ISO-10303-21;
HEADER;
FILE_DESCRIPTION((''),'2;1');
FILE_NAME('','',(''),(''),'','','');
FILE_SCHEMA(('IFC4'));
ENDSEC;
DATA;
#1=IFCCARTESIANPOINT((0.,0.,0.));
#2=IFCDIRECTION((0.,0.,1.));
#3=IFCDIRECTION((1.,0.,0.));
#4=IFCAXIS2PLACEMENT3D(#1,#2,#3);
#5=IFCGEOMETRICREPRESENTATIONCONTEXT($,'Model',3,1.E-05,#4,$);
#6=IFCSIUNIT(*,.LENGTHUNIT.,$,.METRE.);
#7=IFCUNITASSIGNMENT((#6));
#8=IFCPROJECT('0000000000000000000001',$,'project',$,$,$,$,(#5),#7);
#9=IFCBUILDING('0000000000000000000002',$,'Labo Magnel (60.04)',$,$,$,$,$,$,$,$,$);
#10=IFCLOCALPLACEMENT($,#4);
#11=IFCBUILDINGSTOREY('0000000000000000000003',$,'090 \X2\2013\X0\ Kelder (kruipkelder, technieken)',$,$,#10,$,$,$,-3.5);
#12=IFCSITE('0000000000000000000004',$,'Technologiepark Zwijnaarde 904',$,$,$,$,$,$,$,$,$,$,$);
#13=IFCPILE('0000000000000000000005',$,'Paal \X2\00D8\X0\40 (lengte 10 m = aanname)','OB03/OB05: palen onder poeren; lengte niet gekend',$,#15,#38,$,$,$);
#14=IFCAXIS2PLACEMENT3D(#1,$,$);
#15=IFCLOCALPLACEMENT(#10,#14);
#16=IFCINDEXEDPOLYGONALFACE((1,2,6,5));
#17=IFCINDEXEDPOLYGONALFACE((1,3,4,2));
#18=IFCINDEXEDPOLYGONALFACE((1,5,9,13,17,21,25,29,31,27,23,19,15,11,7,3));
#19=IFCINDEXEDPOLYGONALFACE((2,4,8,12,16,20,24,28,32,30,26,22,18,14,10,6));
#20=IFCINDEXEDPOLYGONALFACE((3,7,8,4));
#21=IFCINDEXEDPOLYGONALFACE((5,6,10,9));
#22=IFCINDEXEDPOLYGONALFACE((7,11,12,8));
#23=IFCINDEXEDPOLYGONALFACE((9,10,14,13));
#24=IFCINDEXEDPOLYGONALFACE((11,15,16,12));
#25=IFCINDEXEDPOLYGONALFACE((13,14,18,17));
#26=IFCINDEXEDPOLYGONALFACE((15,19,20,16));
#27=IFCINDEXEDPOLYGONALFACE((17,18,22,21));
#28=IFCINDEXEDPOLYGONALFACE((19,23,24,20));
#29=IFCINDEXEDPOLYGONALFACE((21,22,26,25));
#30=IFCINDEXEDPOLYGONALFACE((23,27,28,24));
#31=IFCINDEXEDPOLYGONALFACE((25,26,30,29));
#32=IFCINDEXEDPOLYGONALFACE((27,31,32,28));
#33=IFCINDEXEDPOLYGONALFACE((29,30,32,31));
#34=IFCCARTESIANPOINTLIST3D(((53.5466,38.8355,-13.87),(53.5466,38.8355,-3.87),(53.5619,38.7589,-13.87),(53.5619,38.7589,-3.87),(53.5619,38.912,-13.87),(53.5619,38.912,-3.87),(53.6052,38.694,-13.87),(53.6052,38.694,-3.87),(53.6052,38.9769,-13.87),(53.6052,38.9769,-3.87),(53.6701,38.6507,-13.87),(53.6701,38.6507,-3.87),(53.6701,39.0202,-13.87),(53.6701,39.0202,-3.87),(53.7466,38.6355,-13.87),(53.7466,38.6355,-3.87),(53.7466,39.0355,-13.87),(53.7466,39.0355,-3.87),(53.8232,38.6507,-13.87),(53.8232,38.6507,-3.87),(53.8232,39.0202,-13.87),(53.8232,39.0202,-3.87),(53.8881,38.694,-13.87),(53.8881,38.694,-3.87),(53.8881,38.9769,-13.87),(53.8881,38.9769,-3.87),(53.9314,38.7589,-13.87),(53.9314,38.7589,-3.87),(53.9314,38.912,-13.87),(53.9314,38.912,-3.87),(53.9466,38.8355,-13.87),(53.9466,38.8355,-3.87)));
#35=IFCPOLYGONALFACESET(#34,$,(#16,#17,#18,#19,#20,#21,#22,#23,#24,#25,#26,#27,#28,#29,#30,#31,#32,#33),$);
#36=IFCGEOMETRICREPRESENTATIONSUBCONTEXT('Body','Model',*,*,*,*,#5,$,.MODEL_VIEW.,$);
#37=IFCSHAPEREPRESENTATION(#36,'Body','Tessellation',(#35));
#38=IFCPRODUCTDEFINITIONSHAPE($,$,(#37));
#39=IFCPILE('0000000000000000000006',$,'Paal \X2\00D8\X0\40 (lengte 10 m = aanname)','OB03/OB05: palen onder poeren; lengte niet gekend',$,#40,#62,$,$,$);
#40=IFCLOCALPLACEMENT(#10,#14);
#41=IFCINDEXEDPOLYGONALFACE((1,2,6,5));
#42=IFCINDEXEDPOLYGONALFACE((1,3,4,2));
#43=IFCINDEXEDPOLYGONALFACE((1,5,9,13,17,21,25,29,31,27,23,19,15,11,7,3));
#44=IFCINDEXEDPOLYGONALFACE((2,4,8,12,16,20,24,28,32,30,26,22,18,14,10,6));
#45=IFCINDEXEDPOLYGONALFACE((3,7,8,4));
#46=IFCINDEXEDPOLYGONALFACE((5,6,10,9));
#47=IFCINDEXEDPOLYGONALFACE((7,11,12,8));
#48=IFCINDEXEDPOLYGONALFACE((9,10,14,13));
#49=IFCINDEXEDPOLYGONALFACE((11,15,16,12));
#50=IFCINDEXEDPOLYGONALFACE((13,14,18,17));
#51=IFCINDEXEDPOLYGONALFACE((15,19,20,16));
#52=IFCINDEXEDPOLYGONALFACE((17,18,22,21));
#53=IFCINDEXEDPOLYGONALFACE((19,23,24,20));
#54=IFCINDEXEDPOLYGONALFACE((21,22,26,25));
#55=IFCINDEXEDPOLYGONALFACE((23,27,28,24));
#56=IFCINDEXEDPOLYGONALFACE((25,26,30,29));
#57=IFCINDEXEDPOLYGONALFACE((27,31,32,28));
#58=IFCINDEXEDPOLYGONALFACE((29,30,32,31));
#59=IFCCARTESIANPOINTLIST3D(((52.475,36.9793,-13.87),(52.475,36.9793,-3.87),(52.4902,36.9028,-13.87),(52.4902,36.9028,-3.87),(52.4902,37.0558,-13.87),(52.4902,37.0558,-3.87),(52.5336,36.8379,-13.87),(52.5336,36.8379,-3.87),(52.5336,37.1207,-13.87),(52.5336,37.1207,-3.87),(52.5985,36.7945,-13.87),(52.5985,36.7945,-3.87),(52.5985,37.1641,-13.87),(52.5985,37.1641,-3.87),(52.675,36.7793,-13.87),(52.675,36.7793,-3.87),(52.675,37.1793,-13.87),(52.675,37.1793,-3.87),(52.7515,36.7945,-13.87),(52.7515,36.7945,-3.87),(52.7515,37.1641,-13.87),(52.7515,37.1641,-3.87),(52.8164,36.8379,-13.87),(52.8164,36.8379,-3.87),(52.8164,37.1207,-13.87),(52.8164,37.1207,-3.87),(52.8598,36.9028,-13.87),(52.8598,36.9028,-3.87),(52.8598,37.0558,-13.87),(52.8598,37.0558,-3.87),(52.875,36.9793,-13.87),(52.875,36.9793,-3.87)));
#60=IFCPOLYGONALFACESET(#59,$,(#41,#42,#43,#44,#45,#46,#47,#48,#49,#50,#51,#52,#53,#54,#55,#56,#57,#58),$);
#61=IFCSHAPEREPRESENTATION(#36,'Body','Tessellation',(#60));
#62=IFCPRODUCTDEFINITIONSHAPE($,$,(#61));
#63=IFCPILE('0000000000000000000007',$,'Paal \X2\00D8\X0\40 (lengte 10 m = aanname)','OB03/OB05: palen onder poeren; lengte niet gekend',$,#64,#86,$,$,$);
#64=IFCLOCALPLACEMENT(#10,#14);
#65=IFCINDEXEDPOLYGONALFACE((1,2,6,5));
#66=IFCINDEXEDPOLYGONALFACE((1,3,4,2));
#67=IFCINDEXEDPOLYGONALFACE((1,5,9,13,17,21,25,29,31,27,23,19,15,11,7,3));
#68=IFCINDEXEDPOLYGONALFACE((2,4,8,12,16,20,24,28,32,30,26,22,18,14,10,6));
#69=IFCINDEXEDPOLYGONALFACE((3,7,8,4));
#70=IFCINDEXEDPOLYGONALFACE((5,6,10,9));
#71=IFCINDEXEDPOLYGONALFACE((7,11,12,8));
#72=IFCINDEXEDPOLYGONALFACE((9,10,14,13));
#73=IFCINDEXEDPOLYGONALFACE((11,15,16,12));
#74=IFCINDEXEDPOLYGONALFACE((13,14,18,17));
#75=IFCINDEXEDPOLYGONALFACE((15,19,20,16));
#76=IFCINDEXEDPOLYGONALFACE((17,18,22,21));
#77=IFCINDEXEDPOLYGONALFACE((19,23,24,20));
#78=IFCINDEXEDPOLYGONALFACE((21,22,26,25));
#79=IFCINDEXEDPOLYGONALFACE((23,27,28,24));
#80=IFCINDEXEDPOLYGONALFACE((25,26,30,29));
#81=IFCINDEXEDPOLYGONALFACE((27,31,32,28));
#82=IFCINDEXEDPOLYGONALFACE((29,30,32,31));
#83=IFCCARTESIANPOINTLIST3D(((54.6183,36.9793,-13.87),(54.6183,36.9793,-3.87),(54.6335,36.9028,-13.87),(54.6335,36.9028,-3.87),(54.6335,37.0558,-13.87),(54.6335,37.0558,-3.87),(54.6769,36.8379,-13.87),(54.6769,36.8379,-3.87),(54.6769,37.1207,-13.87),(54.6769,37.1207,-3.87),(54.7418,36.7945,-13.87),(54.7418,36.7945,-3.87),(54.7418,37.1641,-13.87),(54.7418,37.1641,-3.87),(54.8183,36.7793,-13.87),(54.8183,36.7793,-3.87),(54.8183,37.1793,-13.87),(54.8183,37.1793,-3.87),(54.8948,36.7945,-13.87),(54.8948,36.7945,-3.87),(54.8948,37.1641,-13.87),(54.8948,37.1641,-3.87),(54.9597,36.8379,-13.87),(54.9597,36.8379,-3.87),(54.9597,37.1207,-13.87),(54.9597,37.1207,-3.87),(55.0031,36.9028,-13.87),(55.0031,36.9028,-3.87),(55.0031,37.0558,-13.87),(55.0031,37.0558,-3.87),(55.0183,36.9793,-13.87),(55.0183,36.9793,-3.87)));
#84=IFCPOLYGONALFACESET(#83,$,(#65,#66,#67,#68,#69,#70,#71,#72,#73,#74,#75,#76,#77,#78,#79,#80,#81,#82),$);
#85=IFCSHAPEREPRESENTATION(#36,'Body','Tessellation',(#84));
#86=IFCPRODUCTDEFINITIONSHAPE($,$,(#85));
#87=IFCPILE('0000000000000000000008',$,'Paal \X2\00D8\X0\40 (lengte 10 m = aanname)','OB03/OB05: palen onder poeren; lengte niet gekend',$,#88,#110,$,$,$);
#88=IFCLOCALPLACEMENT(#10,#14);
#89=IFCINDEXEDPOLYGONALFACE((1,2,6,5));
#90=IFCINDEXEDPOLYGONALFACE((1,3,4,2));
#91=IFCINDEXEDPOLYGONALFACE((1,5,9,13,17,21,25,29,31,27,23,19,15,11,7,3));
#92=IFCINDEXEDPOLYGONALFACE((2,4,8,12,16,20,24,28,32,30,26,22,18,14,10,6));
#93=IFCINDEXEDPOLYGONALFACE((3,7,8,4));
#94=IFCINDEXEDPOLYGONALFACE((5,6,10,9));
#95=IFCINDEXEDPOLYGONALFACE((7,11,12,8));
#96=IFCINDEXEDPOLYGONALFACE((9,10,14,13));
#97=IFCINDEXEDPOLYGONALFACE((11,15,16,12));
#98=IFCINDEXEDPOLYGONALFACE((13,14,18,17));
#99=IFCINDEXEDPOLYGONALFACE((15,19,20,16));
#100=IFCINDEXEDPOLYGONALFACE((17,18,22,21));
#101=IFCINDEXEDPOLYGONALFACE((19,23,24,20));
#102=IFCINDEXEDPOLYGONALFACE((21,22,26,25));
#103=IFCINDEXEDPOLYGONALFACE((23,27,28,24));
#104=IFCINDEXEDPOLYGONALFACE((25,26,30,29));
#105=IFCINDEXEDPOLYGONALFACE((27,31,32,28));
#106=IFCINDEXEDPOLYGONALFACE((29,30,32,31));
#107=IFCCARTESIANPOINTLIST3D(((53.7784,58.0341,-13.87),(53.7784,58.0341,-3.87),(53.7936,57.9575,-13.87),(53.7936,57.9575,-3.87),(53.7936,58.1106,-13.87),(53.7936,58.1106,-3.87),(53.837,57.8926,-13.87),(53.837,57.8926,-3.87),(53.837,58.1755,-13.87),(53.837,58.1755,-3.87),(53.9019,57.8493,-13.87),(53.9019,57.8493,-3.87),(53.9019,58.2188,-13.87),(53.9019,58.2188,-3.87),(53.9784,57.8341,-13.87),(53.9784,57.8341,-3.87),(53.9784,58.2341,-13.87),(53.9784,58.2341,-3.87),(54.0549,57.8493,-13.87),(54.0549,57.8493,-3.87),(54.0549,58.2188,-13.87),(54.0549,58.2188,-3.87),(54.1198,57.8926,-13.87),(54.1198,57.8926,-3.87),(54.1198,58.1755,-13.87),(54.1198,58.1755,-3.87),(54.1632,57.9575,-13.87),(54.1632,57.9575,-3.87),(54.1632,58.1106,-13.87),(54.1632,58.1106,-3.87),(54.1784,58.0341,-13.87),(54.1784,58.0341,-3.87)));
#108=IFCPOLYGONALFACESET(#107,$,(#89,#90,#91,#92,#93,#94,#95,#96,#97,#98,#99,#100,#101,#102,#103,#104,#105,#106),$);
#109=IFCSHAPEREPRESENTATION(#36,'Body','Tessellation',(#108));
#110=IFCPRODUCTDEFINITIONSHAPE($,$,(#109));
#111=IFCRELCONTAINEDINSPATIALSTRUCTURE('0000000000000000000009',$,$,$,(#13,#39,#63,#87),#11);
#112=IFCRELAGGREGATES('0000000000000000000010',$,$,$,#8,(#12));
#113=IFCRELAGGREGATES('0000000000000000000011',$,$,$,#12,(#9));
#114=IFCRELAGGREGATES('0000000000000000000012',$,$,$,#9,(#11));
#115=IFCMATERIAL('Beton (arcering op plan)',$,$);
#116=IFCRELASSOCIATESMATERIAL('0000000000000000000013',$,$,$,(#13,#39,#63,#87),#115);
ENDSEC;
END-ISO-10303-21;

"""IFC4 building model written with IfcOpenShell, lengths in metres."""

from ifc_helpers import new_model, si_unit, frame, origin, origin_with_axes, place, context, subcontext, project, spatial, polyline, outline, extrude, material, element, save


model = new_model("IFC4")

# Units and contexts
model_context = context("Model", 3, precision=1e-05, world=origin_with_axes())
body_context = subcontext(model_context, "Body", "Model", "MODEL_VIEW")
ifc_project = project(units=[si_unit("LENGTHUNIT", "METRE")], contexts=[model_context])

# Site, building, storey
site = spatial("IfcSite", under=ifc_project, Name="Technologiepark Zwijnaarde 904")
building = spatial("IfcBuilding", under=site, Name="Labo Magnel (60.04)")
storey_placement = place(None, origin_with_axes())
storey = spatial("IfcBuildingStorey", under=building, at=storey_placement, Name="090 – Kelder (kruipkelder, technieken)", Elevation=-3.5)

# Piles
ifc_material = material(Name="Beton (arcering op plan)")
pile_1_placement = place(storey_placement, frame((0.0, 0.0, -13.87), z_axis=(0.0, 0.0, 1.0), x_axis=(1.0, 0.0, 0.0)))
element("IfcPile", 1, at=pile_1_placement, inside=storey, material=ifc_material, Name="Paal Ø40 (lengte 10 m = aanname)", Description="OB03/OB05: palen onder poeren; lengte niet gekend", context=body_context, shape_type="SweptSolid", body=[
    extrude(outline(polyline([(53.9466, 38.8355), (53.9314, 38.7589), (53.8881, 38.694), (53.8232, 38.6507), (53.7466, 38.6355), (53.6701, 38.6507), (53.6052, 38.694), (53.5619, 38.7589), (53.5466, 38.8355), (53.5619, 38.912), (53.6052, 38.9769), (53.6701, 39.0202), (53.7466, 39.0355), (53.8232, 39.0202), (53.8881, 38.9769), (53.9314, 38.912), (53.9466, 38.8355)])), origin(), (0.0, 0.0, 1.0), 10.0),
])
pile_2_placement = place(storey_placement, frame((0.0, 0.0, -13.87), z_axis=(0.0, 0.0, 1.0), x_axis=(1.0, 0.0, 0.0)))
element("IfcPile", 2, at=pile_2_placement, inside=storey, material=ifc_material, Name="Paal Ø40 (lengte 10 m = aanname)", Description="OB03/OB05: palen onder poeren; lengte niet gekend", context=body_context, shape_type="SweptSolid", body=[
    extrude(outline(polyline([(52.875, 36.9793), (52.8598, 36.9028), (52.8164, 36.8379), (52.7515, 36.7945), (52.675, 36.7793), (52.5985, 36.7945), (52.5336, 36.8379), (52.4902, 36.9028), (52.475, 36.9793), (52.4902, 37.0558), (52.5336, 37.1207), (52.5985, 37.1641), (52.675, 37.1793), (52.7515, 37.1641), (52.8164, 37.1207), (52.8598, 37.0558), (52.875, 36.9793)])), origin(), (0.0, 0.0, 1.0), 10.0),
])
pile_3_placement = place(storey_placement, frame((0.0, 0.0, -13.87), z_axis=(0.0, 0.0, 1.0), x_axis=(1.0, 0.0, 0.0)))
element("IfcPile", 3, at=pile_3_placement, inside=storey, material=ifc_material, Name="Paal Ø40 (lengte 10 m = aanname)", Description="OB03/OB05: palen onder poeren; lengte niet gekend", context=body_context, shape_type="SweptSolid", body=[
    extrude(outline(polyline([(55.0183, 36.9793), (55.0031, 36.9028), (54.9597, 36.8379), (54.8948, 36.7945), (54.8183, 36.7793), (54.7418, 36.7945), (54.6769, 36.8379), (54.6335, 36.9028), (54.6183, 36.9793), (54.6335, 37.0558), (54.6769, 37.1207), (54.7418, 37.1641), (54.8183, 37.1793), (54.8948, 37.1641), (54.9597, 37.1207), (55.0031, 37.0558), (55.0183, 36.9793)])), origin(), (0.0, 0.0, 1.0), 10.0),
])
pile_4_placement = place(storey_placement, frame((0.0, 0.0, -13.87), z_axis=(0.0, 0.0, 1.0), x_axis=(1.0, 0.0, 0.0)))
element("IfcPile", 4, at=pile_4_placement, inside=storey, material=ifc_material, Name="Paal Ø40 (lengte 10 m = aanname)", Description="OB03/OB05: palen onder poeren; lengte niet gekend", context=body_context, shape_type="SweptSolid", body=[
    extrude(outline(polyline([(54.1784, 58.0341), (54.1632, 57.9575), (54.1198, 57.8926), (54.0549, 57.8493), (53.9784, 57.8341), (53.9019, 57.8493), (53.837, 57.8926), (53.7936, 57.9575), (53.7784, 58.0341), (53.7936, 58.1106), (53.837, 58.1755), (53.9019, 58.2188), (53.9784, 58.2341), (54.0549, 58.2188), (54.1198, 58.1755), (54.1632, 58.1106), (54.1784, 58.0341)])), origin(), (0.0, 0.0, 1.0), 10.0),
])

save(model, "model.ifc")
